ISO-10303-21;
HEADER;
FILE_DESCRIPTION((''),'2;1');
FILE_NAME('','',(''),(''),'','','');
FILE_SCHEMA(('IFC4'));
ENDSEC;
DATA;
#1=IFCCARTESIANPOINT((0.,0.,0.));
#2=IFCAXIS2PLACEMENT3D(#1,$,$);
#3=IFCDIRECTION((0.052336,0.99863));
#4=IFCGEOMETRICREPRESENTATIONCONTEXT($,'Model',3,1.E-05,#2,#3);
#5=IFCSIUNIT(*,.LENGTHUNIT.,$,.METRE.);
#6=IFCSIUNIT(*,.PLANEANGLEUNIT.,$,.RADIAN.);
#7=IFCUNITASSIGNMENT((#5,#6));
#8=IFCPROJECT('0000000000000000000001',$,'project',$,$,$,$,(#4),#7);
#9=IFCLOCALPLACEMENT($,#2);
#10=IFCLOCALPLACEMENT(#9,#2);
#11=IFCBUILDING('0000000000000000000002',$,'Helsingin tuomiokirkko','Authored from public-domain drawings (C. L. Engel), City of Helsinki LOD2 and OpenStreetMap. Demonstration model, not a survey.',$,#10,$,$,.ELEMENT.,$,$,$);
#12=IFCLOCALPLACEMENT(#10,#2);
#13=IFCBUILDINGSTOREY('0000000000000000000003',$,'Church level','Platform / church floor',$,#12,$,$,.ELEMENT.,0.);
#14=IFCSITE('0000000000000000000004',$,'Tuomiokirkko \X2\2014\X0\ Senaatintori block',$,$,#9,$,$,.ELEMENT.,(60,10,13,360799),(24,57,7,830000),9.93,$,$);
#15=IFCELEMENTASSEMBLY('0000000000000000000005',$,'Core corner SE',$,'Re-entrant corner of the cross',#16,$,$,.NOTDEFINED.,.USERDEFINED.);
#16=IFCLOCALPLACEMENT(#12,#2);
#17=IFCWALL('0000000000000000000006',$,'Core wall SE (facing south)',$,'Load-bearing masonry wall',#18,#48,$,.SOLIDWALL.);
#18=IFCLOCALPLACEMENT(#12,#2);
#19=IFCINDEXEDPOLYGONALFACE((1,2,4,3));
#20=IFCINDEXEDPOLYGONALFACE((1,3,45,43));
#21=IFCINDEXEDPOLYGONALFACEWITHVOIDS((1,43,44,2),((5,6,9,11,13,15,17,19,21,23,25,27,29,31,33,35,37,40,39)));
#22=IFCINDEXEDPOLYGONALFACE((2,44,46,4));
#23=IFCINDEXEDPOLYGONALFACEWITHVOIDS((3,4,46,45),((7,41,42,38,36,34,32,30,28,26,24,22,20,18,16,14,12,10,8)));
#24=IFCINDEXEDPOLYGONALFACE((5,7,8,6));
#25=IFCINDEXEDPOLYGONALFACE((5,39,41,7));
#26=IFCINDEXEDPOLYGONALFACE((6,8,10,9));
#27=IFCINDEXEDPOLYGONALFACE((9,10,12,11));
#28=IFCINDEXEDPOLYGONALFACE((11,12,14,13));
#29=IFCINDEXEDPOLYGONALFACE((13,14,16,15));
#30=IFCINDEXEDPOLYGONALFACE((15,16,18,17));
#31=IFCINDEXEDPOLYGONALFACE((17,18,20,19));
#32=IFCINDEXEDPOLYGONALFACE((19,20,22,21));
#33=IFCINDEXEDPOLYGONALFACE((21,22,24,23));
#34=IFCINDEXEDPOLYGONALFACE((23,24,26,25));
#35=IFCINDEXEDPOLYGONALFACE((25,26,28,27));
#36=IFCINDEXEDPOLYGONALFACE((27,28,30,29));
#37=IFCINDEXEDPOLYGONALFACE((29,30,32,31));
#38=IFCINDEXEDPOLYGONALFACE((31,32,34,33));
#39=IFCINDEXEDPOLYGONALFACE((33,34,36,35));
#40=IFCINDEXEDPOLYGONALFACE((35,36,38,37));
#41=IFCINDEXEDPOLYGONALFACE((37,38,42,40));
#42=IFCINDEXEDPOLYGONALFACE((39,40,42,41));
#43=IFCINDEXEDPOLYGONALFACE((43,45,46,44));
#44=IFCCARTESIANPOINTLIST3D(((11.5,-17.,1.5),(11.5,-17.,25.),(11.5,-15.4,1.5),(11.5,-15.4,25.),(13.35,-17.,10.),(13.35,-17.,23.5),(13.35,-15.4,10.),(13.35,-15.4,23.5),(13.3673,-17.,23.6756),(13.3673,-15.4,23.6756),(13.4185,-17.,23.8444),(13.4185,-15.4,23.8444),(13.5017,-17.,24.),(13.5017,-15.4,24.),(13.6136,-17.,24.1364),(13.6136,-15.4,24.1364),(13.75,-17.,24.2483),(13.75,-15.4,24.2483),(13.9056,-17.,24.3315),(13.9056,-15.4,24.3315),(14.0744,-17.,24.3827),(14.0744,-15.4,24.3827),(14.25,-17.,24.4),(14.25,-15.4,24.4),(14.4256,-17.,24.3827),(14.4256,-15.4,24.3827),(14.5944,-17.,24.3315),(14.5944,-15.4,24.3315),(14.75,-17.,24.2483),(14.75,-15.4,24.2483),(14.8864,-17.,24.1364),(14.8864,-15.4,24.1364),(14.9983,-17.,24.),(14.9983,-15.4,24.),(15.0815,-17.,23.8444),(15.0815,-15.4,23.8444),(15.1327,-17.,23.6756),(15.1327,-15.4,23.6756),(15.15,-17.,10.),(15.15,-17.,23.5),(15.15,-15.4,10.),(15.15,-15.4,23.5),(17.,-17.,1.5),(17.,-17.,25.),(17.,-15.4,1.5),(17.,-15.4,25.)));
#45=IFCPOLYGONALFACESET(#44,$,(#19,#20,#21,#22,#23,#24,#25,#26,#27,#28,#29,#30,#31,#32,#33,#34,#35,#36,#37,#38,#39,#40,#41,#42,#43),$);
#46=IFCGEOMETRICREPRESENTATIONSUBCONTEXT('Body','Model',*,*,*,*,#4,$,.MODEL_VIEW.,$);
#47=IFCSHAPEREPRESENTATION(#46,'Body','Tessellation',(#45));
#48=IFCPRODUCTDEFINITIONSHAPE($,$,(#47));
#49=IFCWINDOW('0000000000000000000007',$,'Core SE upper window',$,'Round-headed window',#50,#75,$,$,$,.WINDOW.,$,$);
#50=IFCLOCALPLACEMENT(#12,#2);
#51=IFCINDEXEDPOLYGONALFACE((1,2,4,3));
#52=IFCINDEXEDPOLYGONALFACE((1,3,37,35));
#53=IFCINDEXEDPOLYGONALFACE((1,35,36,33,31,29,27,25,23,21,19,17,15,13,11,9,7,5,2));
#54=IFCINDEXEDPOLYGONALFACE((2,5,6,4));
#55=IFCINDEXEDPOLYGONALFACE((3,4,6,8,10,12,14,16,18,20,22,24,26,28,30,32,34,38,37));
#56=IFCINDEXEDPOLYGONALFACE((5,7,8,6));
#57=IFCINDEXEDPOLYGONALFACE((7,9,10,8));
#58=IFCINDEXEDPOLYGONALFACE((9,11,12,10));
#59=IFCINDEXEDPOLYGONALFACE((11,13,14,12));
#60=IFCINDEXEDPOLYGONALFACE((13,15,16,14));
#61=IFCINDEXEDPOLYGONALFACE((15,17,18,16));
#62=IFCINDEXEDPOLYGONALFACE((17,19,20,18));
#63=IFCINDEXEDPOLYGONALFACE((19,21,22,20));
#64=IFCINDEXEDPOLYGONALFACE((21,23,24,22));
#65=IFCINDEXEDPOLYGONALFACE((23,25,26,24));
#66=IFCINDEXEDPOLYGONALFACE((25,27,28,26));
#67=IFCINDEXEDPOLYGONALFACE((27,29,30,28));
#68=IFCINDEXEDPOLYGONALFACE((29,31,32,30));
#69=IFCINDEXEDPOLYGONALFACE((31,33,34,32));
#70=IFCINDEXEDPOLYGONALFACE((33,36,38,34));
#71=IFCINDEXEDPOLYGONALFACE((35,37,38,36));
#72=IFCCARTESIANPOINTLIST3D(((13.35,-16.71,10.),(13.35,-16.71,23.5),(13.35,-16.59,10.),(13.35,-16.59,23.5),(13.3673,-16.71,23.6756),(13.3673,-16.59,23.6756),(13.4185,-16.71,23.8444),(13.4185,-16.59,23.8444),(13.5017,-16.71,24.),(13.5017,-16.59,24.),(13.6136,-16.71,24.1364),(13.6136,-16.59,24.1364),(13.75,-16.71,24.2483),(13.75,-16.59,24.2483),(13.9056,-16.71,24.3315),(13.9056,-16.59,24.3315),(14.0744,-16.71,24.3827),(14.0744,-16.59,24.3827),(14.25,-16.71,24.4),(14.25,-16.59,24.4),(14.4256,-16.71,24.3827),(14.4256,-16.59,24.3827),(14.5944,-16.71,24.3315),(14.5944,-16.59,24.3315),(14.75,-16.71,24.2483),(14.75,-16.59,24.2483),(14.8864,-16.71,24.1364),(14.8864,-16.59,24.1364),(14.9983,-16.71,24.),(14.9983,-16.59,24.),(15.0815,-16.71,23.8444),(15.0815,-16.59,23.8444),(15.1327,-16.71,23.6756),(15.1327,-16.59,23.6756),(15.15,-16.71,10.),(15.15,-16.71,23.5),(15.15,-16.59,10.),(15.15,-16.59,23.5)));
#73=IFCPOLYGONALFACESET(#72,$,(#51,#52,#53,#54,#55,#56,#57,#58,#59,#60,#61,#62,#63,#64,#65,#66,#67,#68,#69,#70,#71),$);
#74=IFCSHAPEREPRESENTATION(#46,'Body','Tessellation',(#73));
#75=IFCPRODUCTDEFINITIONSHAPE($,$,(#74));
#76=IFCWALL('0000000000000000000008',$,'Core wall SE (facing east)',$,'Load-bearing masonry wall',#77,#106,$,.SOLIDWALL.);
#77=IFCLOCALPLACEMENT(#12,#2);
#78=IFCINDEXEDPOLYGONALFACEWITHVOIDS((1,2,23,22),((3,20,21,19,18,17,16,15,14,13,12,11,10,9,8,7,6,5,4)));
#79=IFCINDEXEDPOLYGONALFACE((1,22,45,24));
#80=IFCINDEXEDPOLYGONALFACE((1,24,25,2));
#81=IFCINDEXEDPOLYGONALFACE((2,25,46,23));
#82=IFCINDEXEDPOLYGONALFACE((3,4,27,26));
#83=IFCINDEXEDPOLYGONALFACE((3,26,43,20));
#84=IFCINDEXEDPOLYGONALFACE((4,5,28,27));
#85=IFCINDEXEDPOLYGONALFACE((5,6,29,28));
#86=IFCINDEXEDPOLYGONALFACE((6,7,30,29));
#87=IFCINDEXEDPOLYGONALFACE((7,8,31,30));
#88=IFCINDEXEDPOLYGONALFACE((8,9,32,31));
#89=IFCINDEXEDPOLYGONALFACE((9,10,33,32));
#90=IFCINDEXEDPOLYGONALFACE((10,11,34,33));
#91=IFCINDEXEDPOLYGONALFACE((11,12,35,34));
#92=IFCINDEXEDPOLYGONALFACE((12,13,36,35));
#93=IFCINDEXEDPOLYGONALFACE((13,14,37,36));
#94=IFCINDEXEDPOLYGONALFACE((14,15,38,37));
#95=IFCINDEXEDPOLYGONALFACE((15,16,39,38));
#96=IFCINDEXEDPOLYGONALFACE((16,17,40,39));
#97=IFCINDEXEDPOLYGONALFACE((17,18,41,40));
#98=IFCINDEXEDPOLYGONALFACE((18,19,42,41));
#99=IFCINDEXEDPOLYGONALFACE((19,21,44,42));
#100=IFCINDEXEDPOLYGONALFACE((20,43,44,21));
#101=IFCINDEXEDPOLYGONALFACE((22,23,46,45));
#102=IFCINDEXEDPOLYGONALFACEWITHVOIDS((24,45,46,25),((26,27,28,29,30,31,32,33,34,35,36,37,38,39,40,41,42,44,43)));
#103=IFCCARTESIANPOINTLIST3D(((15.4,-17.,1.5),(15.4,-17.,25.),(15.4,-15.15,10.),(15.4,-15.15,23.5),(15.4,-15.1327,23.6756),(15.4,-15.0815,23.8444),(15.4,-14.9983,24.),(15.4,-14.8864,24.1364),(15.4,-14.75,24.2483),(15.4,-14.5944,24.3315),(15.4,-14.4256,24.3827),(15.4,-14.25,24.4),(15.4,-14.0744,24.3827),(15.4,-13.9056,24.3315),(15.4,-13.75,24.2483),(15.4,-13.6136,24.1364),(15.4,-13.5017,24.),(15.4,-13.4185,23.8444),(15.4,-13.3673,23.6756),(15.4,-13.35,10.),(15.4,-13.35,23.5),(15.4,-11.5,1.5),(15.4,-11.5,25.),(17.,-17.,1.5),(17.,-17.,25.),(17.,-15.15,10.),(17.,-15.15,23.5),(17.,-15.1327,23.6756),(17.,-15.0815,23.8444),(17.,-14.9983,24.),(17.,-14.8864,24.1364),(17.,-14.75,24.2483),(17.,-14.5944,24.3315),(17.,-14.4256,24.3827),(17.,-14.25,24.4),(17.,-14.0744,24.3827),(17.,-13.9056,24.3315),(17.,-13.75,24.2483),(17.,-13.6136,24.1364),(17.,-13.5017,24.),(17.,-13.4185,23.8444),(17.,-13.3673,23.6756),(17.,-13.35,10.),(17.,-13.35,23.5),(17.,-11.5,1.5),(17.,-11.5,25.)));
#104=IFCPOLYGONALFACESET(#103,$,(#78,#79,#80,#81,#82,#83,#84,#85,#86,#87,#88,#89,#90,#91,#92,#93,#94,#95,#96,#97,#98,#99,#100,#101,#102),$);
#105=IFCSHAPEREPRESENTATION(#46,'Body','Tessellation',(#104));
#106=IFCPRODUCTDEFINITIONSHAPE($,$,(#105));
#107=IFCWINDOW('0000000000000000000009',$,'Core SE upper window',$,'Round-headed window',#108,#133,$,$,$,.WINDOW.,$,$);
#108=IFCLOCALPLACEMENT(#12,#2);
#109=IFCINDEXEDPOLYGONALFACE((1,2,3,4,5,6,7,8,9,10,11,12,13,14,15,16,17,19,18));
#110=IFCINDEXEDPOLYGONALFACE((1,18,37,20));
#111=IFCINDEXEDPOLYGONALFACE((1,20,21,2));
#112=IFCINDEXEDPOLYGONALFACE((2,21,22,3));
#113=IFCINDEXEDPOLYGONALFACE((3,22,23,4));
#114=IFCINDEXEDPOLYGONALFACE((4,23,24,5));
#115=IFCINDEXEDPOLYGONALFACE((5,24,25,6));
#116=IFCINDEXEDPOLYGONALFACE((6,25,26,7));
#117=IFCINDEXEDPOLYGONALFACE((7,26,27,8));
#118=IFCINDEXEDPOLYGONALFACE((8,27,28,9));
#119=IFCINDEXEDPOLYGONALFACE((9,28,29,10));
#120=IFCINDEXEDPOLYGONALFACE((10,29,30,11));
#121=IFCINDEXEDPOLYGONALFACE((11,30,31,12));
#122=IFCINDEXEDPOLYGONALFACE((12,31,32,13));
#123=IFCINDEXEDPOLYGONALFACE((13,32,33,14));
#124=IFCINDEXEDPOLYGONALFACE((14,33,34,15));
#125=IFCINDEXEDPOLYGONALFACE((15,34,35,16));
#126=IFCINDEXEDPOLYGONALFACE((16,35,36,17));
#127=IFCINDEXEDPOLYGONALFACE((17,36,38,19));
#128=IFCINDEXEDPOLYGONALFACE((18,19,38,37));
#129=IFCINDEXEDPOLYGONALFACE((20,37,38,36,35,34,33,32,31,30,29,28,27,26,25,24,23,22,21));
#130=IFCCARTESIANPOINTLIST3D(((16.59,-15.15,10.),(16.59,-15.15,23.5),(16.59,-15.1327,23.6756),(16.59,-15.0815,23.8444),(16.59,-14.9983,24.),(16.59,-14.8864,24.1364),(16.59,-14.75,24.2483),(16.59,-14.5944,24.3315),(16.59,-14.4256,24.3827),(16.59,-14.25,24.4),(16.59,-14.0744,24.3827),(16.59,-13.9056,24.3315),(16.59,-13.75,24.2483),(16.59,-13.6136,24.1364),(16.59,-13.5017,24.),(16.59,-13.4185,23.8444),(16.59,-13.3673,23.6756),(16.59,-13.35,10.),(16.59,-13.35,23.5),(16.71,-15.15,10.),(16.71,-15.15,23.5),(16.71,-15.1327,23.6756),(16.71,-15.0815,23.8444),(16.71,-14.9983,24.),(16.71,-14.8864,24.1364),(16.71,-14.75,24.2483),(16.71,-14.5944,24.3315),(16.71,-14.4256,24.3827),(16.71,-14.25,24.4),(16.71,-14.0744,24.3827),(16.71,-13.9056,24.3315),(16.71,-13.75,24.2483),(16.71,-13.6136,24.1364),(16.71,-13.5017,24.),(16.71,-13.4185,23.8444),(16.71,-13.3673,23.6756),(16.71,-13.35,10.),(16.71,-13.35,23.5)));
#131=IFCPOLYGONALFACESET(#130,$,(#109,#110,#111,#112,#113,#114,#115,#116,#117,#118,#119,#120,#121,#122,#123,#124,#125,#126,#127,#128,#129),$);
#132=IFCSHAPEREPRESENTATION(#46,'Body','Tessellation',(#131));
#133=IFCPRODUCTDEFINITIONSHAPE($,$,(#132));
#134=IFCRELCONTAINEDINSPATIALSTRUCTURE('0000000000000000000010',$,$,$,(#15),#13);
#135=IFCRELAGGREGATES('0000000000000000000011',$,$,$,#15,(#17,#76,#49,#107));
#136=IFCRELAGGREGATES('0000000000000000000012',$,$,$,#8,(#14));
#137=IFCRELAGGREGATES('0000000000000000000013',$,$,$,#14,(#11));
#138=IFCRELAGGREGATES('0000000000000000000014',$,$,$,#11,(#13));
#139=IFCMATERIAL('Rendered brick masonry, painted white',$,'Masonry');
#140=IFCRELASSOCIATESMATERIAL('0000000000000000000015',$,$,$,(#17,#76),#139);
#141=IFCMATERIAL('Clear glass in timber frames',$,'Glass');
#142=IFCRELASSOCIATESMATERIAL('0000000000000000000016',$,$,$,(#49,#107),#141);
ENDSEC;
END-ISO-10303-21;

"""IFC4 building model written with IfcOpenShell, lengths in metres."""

from ifc_helpers import new_model, si_unit, direction, frame, frame_2d, origin, origin_2d_with_axis, place, context, subcontext, project, spatial, polyline, rectangle, outline, extrude, material, element, fill, aggregate, save


model = new_model("IFC4")

# Units and contexts
model_context = context("Model", 3, precision=1e-05, world=origin(), true_north=direction((0.052336, 0.99863)))
body_context = subcontext(model_context, "Body", "Model", "MODEL_VIEW")
ifc_project = project(units=[si_unit("LENGTHUNIT", "METRE"), si_unit("PLANEANGLEUNIT", "RADIAN")], contexts=[model_context])

# Site, building, storey
site_placement = place(None, origin())
site = spatial("IfcSite", under=ifc_project, at=site_placement, Name="Tuomiokirkko — Senaatintori block", CompositionType="ELEMENT", RefLatitude=(60, 10, 13, 360799), RefLongitude=(24, 57, 7, 830000), RefElevation=9.93)
building_placement = place(site_placement, origin())
building = spatial("IfcBuilding", under=site, at=building_placement, Name="Helsingin tuomiokirkko", Description="Authored from public-domain drawings (C. L. Engel), City of Helsinki LOD2 and OpenStreetMap. Demonstration model, not a survey.", CompositionType="ELEMENT")
storey_placement = place(building_placement, origin())
storey = spatial("IfcBuildingStorey", under=building, at=storey_placement, Name="Church level", Description="Platform / church floor", CompositionType="ELEMENT", Elevation=0.0)

# Element assembly, walls, openings, windows
ifc_material_1 = material(Name="Rendered brick masonry, painted white", Category="Masonry")
ifc_material_2 = material(Name="Clear glass in timber frames", Category="Glass")
assembly_1_placement = place(building_placement, origin())
assembly_1 = element("IfcElementAssembly", 1, at=assembly_1_placement, inside=storey, Name="Core corner SE", ObjectType="Re-entrant corner of the cross", AssemblyPlace="NOTDEFINED", PredefinedType="USERDEFINED")
wall_1_placement = place(building_placement, origin())
wall_1 = element("IfcWall", 2, at=wall_1_placement, material=ifc_material_1, Name="Core wall SE (facing south)", ObjectType="Load-bearing masonry wall", PredefinedType="SOLIDWALL", context=body_context, shape_type="SweptSolid", body=[
    extrude(rectangle(XDim=5.5, YDim=1.6, at=origin_2d_with_axis()), frame((14.25, -16.2, 1.5)), (0.0, 0.0, 1.0), 23.5),
])
opening_1_placement = place(building_placement, origin())
opening_1 = element("IfcOpeningElement", 3, at=opening_1_placement, cuts=wall_1, PredefinedType="OPENING", context=body_context, shape_type="SweptSolid", body=[
    extrude(outline(polyline([(-0.9, 0.0), (0.9, 0.0), (0.9, 13.5), (0.8827, 13.6756), (0.8315, 13.8444), (0.7483, 14.0), (0.6364, 14.1364), (0.5, 14.2483), (0.3444, 14.3315), (0.1756, 14.3827), (0.0, 14.4), (-0.1756, 14.3827), (-0.3444, 14.3315), (-0.5, 14.2483), (-0.6364, 14.1364), (-0.7483, 14.0), (-0.8315, 13.8444), (-0.8827, 13.6756), (-0.9, 13.5), (-0.9, 0.0)])), frame((14.25, -15.2, 10.0), z_axis=(0.0, -1.0, 0.0), x_axis=(1.0, 0.0, 0.0)), (0.0, 0.0, 1.0), 2.0),
])
window_1_placement = place(building_placement, origin())
window_1 = element("IfcWindow", 4, at=window_1_placement, material=ifc_material_2, Name="Core SE upper window", ObjectType="Round-headed window", PredefinedType="WINDOW", context=body_context, shape_type="SweptSolid", body=[
    extrude(outline(polyline([(-0.9, 0.0), (0.9, 0.0), (0.9, 13.5), (0.8827, 13.6756), (0.8315, 13.8444), (0.7483, 14.0), (0.6364, 14.1364), (0.5, 14.2483), (0.3444, 14.3315), (0.1756, 14.3827), (0.0, 14.4), (-0.1756, 14.3827), (-0.3444, 14.3315), (-0.5, 14.2483), (-0.6364, 14.1364), (-0.7483, 14.0), (-0.8315, 13.8444), (-0.8827, 13.6756), (-0.9, 13.5), (-0.9, 0.0)])), frame((14.25, -16.59, 10.0), z_axis=(0.0, -1.0, 0.0), x_axis=(1.0, 0.0, 0.0)), (0.0, 0.0, 1.0), 0.12),
])
fill(opening_1, window_1)
wall_2_placement = place(building_placement, origin())
wall_2 = element("IfcWall", 5, at=wall_2_placement, material=ifc_material_1, Name="Core wall SE (facing east)", ObjectType="Load-bearing masonry wall", PredefinedType="SOLIDWALL", context=body_context, shape_type="SweptSolid", body=[
    extrude(rectangle(XDim=5.5, YDim=1.6, at=frame_2d((0.0, 0.0), x_axis=(0.0, -1.0))), frame((16.2, -14.25, 1.5)), (0.0, 0.0, 1.0), 23.5),
])
opening_2_placement = place(building_placement, origin())
opening_2 = element("IfcOpeningElement", 6, at=opening_2_placement, cuts=wall_2, PredefinedType="OPENING", context=body_context, shape_type="SweptSolid", body=[
    extrude(outline(polyline([(-0.9, 0.0), (0.9, 0.0), (0.9, 13.5), (0.8827, 13.6756), (0.8315, 13.8444), (0.7483, 14.0), (0.6364, 14.1364), (0.5, 14.2483), (0.3444, 14.3315), (0.1756, 14.3827), (0.0, 14.4), (-0.1756, 14.3827), (-0.3444, 14.3315), (-0.5, 14.2483), (-0.6364, 14.1364), (-0.7483, 14.0), (-0.8315, 13.8444), (-0.8827, 13.6756), (-0.9, 13.5), (-0.9, 0.0)])), frame((17.2, -14.25, 10.0), z_axis=(-1.0, 0.0, 0.0), x_axis=(0.0, -1.0, 0.0)), (0.0, 0.0, 1.0), 2.0),
])
window_2_placement = place(building_placement, origin())
window_2 = element("IfcWindow", 7, at=window_2_placement, material=ifc_material_2, Name="Core SE upper window", ObjectType="Round-headed window", PredefinedType="WINDOW", context=body_context, shape_type="SweptSolid", body=[
    extrude(outline(polyline([(-0.9, 0.0), (0.9, 0.0), (0.9, 13.5), (0.8827, 13.6756), (0.8315, 13.8444), (0.7483, 14.0), (0.6364, 14.1364), (0.5, 14.2483), (0.3444, 14.3315), (0.1756, 14.3827), (0.0, 14.4), (-0.1756, 14.3827), (-0.3444, 14.3315), (-0.5, 14.2483), (-0.6364, 14.1364), (-0.7483, 14.0), (-0.8315, 13.8444), (-0.8827, 13.6756), (-0.9, 13.5), (-0.9, 0.0)])), frame((16.71, -14.25, 10.0), z_axis=(-1.0, 0.0, 0.0), x_axis=(0.0, -1.0, 0.0)), (0.0, 0.0, 1.0), 0.12),
])
fill(opening_2, window_2)
aggregate(assembly_1, [wall_1, wall_2, window_1, window_2])

save(model, "model.ifc")
